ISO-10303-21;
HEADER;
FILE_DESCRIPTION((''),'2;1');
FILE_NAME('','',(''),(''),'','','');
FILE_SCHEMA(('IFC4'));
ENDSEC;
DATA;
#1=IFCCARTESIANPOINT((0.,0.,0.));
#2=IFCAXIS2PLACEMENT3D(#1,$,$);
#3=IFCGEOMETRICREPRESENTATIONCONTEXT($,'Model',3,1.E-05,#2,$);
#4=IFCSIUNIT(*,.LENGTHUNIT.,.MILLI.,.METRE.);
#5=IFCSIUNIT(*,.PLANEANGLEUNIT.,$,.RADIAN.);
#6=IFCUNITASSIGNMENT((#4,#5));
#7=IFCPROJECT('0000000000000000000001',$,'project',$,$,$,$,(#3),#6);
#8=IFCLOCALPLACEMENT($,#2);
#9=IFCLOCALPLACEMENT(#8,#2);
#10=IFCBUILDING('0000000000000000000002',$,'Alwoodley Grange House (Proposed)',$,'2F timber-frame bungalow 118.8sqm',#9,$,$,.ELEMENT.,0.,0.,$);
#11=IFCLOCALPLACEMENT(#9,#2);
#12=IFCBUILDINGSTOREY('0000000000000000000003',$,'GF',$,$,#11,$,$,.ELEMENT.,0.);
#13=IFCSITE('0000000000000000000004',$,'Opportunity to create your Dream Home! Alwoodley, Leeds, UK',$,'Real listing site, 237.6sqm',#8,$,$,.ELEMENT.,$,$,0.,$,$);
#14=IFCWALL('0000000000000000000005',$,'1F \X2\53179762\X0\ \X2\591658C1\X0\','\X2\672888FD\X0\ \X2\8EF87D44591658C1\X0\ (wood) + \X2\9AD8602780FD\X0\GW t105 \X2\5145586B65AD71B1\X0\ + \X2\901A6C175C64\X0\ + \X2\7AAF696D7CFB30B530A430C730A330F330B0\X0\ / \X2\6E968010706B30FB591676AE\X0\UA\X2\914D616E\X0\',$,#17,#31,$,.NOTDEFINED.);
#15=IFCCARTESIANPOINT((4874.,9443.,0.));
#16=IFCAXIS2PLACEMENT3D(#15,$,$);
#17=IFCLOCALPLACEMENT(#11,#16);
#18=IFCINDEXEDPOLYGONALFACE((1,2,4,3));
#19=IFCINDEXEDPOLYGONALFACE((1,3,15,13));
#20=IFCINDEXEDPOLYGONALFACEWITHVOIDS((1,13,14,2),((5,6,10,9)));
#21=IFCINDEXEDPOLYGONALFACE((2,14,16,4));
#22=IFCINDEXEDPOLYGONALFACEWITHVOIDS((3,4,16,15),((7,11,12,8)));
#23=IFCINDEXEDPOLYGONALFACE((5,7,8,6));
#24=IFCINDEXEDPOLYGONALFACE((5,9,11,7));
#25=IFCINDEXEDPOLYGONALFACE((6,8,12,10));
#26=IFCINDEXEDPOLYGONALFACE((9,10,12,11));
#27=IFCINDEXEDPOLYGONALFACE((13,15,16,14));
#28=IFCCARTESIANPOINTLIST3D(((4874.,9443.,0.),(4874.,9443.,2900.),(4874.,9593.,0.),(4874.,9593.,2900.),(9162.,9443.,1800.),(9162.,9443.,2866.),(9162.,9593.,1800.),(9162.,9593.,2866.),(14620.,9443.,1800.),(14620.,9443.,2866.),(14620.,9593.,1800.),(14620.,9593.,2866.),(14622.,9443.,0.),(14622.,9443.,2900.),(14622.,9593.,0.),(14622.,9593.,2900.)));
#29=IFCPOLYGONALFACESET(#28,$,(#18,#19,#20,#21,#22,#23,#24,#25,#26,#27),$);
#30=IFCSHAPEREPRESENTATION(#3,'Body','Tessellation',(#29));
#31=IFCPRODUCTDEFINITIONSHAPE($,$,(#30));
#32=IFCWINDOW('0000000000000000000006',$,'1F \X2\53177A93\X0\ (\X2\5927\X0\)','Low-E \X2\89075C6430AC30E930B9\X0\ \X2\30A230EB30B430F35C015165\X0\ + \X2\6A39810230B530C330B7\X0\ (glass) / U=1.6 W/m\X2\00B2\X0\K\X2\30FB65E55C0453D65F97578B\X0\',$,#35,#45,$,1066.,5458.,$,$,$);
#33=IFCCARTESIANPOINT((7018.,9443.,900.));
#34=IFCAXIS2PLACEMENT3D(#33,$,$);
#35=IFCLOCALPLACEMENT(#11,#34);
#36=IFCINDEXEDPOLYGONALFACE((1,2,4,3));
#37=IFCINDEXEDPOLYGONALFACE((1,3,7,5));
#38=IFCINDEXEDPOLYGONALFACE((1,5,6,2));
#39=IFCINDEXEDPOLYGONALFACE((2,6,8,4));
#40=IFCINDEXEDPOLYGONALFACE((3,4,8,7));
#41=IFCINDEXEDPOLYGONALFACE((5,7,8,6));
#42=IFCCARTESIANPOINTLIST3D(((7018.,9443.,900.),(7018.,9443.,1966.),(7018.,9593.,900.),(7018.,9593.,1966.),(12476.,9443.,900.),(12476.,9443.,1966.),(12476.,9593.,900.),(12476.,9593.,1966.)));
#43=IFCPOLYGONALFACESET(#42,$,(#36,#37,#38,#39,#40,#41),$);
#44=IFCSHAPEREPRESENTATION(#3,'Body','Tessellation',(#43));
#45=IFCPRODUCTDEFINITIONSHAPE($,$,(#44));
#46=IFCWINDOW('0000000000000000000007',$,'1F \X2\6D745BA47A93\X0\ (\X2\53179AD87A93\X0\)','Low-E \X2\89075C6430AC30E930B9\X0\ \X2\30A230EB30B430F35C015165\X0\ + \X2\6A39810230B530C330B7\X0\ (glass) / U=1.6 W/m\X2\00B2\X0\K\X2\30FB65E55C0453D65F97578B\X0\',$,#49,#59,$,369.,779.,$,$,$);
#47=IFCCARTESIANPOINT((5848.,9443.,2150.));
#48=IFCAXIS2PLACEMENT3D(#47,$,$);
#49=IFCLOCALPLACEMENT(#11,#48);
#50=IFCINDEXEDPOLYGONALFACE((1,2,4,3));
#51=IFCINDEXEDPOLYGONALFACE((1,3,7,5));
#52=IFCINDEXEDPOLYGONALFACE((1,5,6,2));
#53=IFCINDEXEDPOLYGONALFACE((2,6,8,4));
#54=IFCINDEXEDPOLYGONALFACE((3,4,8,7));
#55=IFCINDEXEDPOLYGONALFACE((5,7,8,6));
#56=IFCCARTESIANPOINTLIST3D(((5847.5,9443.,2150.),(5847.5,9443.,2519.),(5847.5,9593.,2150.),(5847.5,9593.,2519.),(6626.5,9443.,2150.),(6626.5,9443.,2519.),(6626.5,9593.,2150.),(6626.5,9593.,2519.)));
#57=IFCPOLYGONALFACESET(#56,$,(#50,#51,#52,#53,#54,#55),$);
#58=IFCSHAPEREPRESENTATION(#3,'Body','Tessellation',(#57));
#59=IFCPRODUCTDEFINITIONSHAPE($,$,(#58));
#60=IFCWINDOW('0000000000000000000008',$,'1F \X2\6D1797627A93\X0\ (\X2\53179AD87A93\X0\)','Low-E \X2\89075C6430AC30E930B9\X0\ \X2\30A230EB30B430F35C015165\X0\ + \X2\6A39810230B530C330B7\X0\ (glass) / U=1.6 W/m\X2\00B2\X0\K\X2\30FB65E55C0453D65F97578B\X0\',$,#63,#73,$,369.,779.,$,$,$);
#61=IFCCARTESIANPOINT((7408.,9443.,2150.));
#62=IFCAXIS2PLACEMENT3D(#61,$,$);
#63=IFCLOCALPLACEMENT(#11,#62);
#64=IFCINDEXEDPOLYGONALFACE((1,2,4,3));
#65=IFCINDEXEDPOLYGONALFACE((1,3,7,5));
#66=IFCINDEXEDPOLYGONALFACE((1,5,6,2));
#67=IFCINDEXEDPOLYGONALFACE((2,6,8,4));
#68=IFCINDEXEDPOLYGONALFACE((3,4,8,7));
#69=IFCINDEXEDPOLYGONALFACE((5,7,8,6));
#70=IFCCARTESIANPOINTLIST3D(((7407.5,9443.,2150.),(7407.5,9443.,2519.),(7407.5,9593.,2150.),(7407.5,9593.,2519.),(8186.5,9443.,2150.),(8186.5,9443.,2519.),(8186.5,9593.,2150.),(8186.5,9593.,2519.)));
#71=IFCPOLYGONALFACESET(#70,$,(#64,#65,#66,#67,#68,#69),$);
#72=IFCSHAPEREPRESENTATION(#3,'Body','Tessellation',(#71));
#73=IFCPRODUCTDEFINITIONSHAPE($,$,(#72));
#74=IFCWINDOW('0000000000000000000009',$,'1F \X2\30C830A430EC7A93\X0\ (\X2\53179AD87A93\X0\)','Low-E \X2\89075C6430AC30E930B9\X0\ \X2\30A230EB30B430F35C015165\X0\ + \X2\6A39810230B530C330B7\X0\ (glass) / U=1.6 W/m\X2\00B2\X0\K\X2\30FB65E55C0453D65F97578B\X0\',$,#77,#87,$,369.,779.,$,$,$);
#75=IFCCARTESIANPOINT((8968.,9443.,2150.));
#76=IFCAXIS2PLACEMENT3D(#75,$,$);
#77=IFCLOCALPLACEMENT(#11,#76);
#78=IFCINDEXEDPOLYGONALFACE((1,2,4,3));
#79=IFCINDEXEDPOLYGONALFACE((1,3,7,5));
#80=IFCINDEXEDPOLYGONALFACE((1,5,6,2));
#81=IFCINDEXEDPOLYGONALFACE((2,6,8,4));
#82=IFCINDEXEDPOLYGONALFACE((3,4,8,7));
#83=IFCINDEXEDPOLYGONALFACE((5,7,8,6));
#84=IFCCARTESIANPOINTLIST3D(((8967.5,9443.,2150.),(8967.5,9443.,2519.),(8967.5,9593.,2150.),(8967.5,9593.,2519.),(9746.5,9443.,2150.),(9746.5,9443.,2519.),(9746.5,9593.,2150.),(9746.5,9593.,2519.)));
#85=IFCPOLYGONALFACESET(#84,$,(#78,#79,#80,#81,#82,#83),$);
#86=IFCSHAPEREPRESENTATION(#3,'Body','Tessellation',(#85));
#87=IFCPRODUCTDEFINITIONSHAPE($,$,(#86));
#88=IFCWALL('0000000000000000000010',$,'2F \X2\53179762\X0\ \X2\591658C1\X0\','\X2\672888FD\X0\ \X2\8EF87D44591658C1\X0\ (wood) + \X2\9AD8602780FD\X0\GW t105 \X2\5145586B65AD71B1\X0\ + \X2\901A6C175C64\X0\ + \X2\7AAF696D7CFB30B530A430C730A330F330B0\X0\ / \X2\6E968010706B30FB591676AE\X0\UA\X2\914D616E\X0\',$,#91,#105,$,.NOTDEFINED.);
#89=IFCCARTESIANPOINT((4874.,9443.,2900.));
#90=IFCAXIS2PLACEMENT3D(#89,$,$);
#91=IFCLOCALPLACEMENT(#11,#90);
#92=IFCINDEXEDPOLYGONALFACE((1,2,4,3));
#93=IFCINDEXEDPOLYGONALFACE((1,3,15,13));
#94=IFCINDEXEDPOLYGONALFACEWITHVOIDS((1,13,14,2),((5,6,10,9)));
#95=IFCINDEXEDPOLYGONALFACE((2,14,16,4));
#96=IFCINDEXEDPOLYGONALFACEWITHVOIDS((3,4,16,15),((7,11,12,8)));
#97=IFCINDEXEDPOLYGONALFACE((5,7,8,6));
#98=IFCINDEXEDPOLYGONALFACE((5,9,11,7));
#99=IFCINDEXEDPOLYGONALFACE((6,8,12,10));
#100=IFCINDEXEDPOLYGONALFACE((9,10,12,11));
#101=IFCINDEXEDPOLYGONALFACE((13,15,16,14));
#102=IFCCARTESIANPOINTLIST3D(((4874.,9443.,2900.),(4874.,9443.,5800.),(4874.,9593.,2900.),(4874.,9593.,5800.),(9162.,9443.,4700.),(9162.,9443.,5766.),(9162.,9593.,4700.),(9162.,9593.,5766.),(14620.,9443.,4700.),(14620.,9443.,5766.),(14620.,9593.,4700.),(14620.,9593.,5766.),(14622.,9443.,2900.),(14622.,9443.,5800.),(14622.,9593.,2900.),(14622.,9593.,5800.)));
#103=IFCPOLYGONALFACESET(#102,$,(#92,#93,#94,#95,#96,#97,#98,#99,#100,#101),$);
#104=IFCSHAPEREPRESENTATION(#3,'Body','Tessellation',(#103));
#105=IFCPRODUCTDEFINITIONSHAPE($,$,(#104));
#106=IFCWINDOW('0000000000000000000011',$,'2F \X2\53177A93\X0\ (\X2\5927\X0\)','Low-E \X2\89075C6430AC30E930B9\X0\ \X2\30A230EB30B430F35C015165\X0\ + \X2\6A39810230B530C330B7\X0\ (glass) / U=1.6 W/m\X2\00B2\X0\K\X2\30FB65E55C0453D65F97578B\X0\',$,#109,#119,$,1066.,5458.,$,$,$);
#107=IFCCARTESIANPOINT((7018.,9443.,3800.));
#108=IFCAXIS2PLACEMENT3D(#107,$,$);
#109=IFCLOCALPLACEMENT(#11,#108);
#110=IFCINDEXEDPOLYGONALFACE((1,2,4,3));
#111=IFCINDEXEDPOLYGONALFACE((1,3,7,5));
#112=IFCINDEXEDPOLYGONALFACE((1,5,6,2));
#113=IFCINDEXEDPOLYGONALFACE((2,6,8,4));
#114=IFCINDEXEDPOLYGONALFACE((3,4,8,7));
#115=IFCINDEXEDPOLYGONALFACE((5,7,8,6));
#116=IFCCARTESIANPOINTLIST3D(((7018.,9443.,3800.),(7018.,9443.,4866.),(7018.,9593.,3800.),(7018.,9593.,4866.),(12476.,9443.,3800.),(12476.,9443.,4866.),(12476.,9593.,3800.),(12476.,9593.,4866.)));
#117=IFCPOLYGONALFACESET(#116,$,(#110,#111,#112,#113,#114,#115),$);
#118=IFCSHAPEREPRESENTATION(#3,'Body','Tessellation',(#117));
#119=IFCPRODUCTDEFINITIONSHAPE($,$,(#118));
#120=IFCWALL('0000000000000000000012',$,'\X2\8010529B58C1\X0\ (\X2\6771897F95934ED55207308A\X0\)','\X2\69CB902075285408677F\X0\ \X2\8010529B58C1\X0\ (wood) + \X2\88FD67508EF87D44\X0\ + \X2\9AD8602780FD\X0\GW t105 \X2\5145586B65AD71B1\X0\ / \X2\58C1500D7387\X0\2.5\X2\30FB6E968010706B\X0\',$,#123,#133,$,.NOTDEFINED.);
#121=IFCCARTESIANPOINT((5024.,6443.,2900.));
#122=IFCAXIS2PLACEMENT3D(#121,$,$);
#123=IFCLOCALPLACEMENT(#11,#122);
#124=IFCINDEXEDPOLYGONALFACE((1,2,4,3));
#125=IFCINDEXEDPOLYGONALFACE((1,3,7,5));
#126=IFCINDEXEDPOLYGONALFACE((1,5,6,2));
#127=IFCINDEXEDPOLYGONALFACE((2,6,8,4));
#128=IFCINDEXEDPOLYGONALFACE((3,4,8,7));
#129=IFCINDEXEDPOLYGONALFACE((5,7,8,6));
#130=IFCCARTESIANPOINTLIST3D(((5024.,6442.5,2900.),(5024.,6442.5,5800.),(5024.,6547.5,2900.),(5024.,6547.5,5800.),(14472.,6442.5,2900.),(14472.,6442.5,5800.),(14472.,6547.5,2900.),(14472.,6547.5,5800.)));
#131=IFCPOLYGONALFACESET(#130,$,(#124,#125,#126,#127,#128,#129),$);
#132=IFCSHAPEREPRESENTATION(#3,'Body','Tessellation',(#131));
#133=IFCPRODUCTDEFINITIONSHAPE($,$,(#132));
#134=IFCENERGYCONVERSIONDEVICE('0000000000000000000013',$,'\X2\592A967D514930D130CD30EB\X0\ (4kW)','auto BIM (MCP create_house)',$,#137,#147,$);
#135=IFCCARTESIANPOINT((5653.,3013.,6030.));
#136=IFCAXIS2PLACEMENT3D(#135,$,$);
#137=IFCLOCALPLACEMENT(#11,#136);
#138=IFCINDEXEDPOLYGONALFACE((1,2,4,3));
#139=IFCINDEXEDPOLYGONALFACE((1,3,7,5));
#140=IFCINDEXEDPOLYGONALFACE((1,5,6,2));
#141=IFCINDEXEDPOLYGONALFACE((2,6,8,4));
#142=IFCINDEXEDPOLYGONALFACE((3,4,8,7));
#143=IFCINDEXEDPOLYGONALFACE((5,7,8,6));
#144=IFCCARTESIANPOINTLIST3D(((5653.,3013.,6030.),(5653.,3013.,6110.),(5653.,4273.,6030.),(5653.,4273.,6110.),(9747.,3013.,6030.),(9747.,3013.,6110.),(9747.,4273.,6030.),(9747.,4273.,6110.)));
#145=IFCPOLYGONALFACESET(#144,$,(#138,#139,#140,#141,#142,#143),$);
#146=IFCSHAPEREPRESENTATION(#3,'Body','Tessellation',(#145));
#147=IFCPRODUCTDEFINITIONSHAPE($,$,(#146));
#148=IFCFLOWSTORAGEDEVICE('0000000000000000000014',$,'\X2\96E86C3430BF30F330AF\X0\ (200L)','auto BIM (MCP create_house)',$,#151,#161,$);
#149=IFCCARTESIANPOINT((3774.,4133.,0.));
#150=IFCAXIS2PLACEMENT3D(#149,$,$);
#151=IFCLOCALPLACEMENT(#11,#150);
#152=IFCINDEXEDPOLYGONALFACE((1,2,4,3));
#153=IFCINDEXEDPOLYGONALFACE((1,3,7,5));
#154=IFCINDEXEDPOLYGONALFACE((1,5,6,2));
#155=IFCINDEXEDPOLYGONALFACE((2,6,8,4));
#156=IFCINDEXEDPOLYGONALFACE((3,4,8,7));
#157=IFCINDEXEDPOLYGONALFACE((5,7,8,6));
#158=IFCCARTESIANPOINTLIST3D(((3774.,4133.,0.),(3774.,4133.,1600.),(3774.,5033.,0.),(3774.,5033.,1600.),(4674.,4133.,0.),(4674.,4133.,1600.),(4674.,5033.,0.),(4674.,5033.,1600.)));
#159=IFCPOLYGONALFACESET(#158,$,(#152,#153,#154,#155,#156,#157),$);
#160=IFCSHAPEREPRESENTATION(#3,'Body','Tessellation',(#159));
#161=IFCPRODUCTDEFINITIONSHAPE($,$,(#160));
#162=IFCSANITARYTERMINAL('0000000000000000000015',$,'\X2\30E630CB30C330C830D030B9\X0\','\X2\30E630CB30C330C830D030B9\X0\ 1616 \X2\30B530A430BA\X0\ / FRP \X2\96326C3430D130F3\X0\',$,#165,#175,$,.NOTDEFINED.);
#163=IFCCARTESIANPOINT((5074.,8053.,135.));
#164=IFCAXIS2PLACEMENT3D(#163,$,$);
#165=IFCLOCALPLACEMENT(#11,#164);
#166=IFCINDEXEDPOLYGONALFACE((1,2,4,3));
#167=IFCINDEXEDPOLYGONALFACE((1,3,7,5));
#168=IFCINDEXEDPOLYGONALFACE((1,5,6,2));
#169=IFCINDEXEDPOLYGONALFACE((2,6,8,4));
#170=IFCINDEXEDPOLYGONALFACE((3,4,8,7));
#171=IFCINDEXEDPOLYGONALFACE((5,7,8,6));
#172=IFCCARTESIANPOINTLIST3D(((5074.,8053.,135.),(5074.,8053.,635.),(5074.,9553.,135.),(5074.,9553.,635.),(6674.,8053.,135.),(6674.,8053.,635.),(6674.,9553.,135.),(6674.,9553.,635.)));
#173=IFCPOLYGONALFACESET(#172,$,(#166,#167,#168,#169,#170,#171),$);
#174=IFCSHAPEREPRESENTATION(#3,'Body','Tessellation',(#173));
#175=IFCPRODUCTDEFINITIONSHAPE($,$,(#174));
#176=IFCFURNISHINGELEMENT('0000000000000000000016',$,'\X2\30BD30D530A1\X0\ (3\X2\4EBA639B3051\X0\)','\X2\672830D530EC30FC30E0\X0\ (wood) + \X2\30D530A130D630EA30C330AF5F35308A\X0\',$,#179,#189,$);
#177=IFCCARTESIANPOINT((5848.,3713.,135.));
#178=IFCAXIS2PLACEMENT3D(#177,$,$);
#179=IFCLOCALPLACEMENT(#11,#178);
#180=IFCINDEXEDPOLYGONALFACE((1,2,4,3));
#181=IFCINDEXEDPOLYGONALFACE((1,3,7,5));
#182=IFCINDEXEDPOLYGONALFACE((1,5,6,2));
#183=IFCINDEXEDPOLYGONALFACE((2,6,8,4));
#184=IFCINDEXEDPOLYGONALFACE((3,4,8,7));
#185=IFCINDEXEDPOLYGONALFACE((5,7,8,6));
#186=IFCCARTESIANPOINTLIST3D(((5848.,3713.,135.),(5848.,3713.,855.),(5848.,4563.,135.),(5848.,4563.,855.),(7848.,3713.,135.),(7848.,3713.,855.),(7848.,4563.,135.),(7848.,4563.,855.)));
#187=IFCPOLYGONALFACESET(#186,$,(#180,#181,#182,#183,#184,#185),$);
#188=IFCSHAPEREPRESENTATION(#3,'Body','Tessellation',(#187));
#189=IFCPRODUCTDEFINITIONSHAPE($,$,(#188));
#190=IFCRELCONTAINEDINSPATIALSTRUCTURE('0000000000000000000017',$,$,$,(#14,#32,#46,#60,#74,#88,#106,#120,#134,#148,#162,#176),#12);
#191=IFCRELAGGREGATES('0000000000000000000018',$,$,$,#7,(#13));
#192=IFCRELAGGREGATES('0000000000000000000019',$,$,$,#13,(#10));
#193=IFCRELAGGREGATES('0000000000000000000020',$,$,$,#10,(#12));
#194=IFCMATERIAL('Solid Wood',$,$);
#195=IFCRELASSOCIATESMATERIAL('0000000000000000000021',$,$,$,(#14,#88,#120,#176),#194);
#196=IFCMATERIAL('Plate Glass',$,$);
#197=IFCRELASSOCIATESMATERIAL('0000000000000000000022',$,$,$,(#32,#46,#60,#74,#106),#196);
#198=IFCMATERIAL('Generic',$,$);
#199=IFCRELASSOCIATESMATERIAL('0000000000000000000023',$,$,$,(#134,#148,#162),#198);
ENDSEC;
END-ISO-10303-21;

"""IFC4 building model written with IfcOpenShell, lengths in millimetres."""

from ifc_helpers import new_model, si_unit, frame, frame_2d, origin, place, context, project, spatial, rectangle, extrude, material, element, fill, save


model = new_model("IFC4")

# Units and contexts
model_context = context("Model", 3, precision=1e-05, world=origin())
ifc_project = project(units=[si_unit("LENGTHUNIT", "METRE", prefix="MILLI"), si_unit("PLANEANGLEUNIT", "RADIAN")], contexts=[model_context])

# Site, building, storey
site_placement = place(None, origin())
site = spatial("IfcSite", under=ifc_project, at=site_placement, Name="Opportunity to create your Dream Home! Alwoodley, Leeds, UK", ObjectType="Real listing site, 237.6sqm", CompositionType="ELEMENT", RefElevation=0.0)
building_placement = place(site_placement, origin())
building = spatial("IfcBuilding", under=site, at=building_placement, Name="Alwoodley Grange House (Proposed)", ObjectType="2F timber-frame bungalow 118.8sqm", CompositionType="ELEMENT", ElevationOfRefHeight=0.0, ElevationOfTerrain=0.0)
storey_placement = place(building_placement, origin())
storey = spatial("IfcBuildingStorey", under=building, at=storey_placement, Name="GF", CompositionType="ELEMENT", Elevation=0.0)

# Wall, openings, windows
ifc_material_1 = material(Name="Solid Wood")
wall_1_placement = place(storey_placement, frame((4874.0, 9443.0, 0.0)))
wall_1 = element("IfcWall", 1, at=wall_1_placement, inside=storey, material=ifc_material_1, Name="1F 北面 外壁", Description="木製 軸組外壁 (wood) + 高性能GW t105 充填断熱 + 通気層 + 窯業系サイディング / 準耐火・外皮UA配慮", PredefinedType="NOTDEFINED", context=model_context, shape_type="SweptSolid", body=[
    extrude(rectangle(XDim=9748.0, YDim=150.0, at=frame_2d((4874.0, 75.0))), frame((4874.0, 9443.0, 0.0)), (0.0, 0.0, 1.0), 2900.0),
])
opening_1_placement = place(storey_placement, frame((7018.0, 9443.0, 900.0)))
opening_1 = element("IfcOpeningElement", 2, at=opening_1_placement, cuts=wall_1, PredefinedType="NOTDEFINED", context=model_context, shape_type="SweptSolid", body=[
    extrude(rectangle(XDim=5458.0, YDim=150.0, at=frame_2d((2729.0, 75.0))), frame((7018.0, 9443.0, 900.0)), (0.0, 0.0, 1.0), 1066.0),
])
opening_2_placement = place(storey_placement, frame((5848.0, 9443.0, 2150.0)))
opening_2 = element("IfcOpeningElement", 3, at=opening_2_placement, cuts=wall_1, PredefinedType="NOTDEFINED", context=model_context, shape_type="SweptSolid", body=[
    extrude(rectangle(XDim=779.0, YDim=150.0, at=frame_2d((389.0, 75.0))), frame((5848.0, 9443.0, 2150.0)), (0.0, 0.0, 1.0), 369.0),
])
opening_3_placement = place(storey_placement, frame((7408.0, 9443.0, 2150.0)))
opening_3 = element("IfcOpeningElement", 4, at=opening_3_placement, cuts=wall_1, PredefinedType="NOTDEFINED", context=model_context, shape_type="SweptSolid", body=[
    extrude(rectangle(XDim=779.0, YDim=150.0, at=frame_2d((389.0, 75.0))), frame((7408.0, 9443.0, 2150.0)), (0.0, 0.0, 1.0), 369.0),
])
opening_4_placement = place(storey_placement, frame((8968.0, 9443.0, 2150.0)))
opening_4 = element("IfcOpeningElement", 5, at=opening_4_placement, cuts=wall_1, PredefinedType="NOTDEFINED", context=model_context, shape_type="SweptSolid", body=[
    extrude(rectangle(XDim=779.0, YDim=150.0, at=frame_2d((389.0, 75.0))), frame((8968.0, 9443.0, 2150.0)), (0.0, 0.0, 1.0), 369.0),
])
ifc_material_2 = material(Name="Plate Glass")
window_1_placement = place(storey_placement, frame((7018.0, 9443.0, 900.0)))
window_1 = element("IfcWindow", 6, at=window_1_placement, inside=storey, material=ifc_material_2, Name="1F 北窓 (大)", Description="Low-E 複層ガラス アルゴン封入 + 樹脂サッシ (glass) / U=1.6 W/m²K・日射取得型", OverallHeight=1066.0, OverallWidth=5458.0, context=model_context, shape_type="SweptSolid", body=[
    extrude(rectangle(XDim=5458.0, YDim=150.0, at=frame_2d((2729.0, 75.0))), frame((7018.0, 9443.0, 900.0)), (0.0, 0.0, 1.0), 1066.0),
])
fill(opening_1, window_1)
window_2_placement = place(storey_placement, frame((5848.0, 9443.0, 2150.0)))
window_2 = element("IfcWindow", 7, at=window_2_placement, inside=storey, material=ifc_material_2, Name="1F 浴室窓 (北高窓)", Description="Low-E 複層ガラス アルゴン封入 + 樹脂サッシ (glass) / U=1.6 W/m²K・日射取得型", OverallHeight=369.0, OverallWidth=779.0, context=model_context, shape_type="SweptSolid", body=[
    extrude(rectangle(XDim=779.0, YDim=150.0, at=frame_2d((389.0, 75.0))), frame((5848.0, 9443.0, 2150.0)), (0.0, 0.0, 1.0), 369.0),
])
fill(opening_2, window_2)
window_3_placement = place(storey_placement, frame((7408.0, 9443.0, 2150.0)))
window_3 = element("IfcWindow", 8, at=window_3_placement, inside=storey, material=ifc_material_2, Name="1F 洗面窓 (北高窓)", Description="Low-E 複層ガラス アルゴン封入 + 樹脂サッシ (glass) / U=1.6 W/m²K・日射取得型", OverallHeight=369.0, OverallWidth=779.0, context=model_context, shape_type="SweptSolid", body=[
    extrude(rectangle(XDim=779.0, YDim=150.0, at=frame_2d((389.0, 75.0))), frame((7408.0, 9443.0, 2150.0)), (0.0, 0.0, 1.0), 369.0),
])
fill(opening_3, window_3)
window_4_placement = place(storey_placement, frame((8968.0, 9443.0, 2150.0)))
window_4 = element("IfcWindow", 9, at=window_4_placement, inside=storey, material=ifc_material_2, Name="1F トイレ窓 (北高窓)", Description="Low-E 複層ガラス アルゴン封入 + 樹脂サッシ (glass) / U=1.6 W/m²K・日射取得型", OverallHeight=369.0, OverallWidth=779.0, context=model_context, shape_type="SweptSolid", body=[
    extrude(rectangle(XDim=779.0, YDim=150.0, at=frame_2d((389.0, 75.0))), frame((8968.0, 9443.0, 2150.0)), (0.0, 0.0, 1.0), 369.0),
])
fill(opening_4, window_4)

# Wall, opening, window
wall_2_placement = place(storey_placement, frame((4874.0, 9443.0, 2900.0)))
wall_2 = element("IfcWall", 10, at=wall_2_placement, inside=storey, material=ifc_material_1, Name="2F 北面 外壁", Description="木製 軸組外壁 (wood) + 高性能GW t105 充填断熱 + 通気層 + 窯業系サイディング / 準耐火・外皮UA配慮", PredefinedType="NOTDEFINED", context=model_context, shape_type="SweptSolid", body=[
    extrude(rectangle(XDim=9748.0, YDim=150.0, at=frame_2d((4874.0, 75.0))), frame((4874.0, 9443.0, 2900.0)), (0.0, 0.0, 1.0), 2900.0),
])
opening_5_placement = place(storey_placement, frame((7018.0, 9443.0, 3800.0)))
opening_5 = element("IfcOpeningElement", 11, at=opening_5_placement, cuts=wall_2, PredefinedType="NOTDEFINED", context=model_context, shape_type="SweptSolid", body=[
    extrude(rectangle(XDim=5458.0, YDim=150.0, at=frame_2d((2729.0, 75.0))), frame((7018.0, 9443.0, 3800.0)), (0.0, 0.0, 1.0), 1066.0),
])
window_5_placement = place(storey_placement, frame((7018.0, 9443.0, 3800.0)))
window_5 = element("IfcWindow", 12, at=window_5_placement, inside=storey, material=ifc_material_2, Name="2F 北窓 (大)", Description="Low-E 複層ガラス アルゴン封入 + 樹脂サッシ (glass) / U=1.6 W/m²K・日射取得型", OverallHeight=1066.0, OverallWidth=5458.0, context=model_context, shape_type="SweptSolid", body=[
    extrude(rectangle(XDim=5458.0, YDim=150.0, at=frame_2d((2729.0, 75.0))), frame((7018.0, 9443.0, 3800.0)), (0.0, 0.0, 1.0), 1066.0),
])
fill(opening_5, window_5)

# Wall
wall_3_placement = place(storey_placement, frame((5024.0, 6443.0, 2900.0)))
element("IfcWall", 13, at=wall_3_placement, inside=storey, material=ifc_material_1, Name="耐力壁 (東西間仕切り)", Description="構造用合板 耐力壁 (wood) + 製材軸組 + 高性能GW t105 充填断熱 / 壁倍率2.5・準耐火", PredefinedType="NOTDEFINED", context=model_context, shape_type="SweptSolid", body=[
    extrude(rectangle(XDim=9448.0, YDim=105.0, at=frame_2d((4724.0, 52.0))), frame((5024.0, 6443.0, 2900.0)), (0.0, 0.0, 1.0), 2900.0),
])

# Energy conversion device
ifc_material_3 = material(Name="Generic")
energy_conversion_device_placement = place(storey_placement, frame((5653.0, 3013.0, 6030.0)))
element("IfcEnergyConversionDevice", 14, at=energy_conversion_device_placement, inside=storey, material=ifc_material_3, Name="太陽光パネル (4kW)", Description="auto BIM (MCP create_house)", context=model_context, shape_type="SweptSolid", body=[
    extrude(rectangle(XDim=4094.0, YDim=1260.0, at=frame_2d((2047.0, 630.0))), frame((5653.0, 3013.0, 6030.0)), (0.0, 0.0, 1.0), 80.0),
])

# Flow storage device
flow_storage_device_placement = place(storey_placement, frame((3774.0, 4133.0, 0.0)))
element("IfcFlowStorageDevice", 15, at=flow_storage_device_placement, inside=storey, material=ifc_material_3, Name="雨水タンク (200L)", Description="auto BIM (MCP create_house)", context=model_context, shape_type="SweptSolid", body=[
    extrude(rectangle(XDim=900.0, YDim=900.0, at=frame_2d((450.0, 450.0))), frame((3774.0, 4133.0, 0.0)), (0.0, 0.0, 1.0), 1600.0),
])

# Sanitary terminal
sanitary_terminal_placement = place(storey_placement, frame((5074.0, 8053.0, 135.0)))
element("IfcSanitaryTerminal", 16, at=sanitary_terminal_placement, inside=storey, material=ifc_material_3, Name="ユニットバス", Description="ユニットバス 1616 サイズ / FRP 防水パン", PredefinedType="NOTDEFINED", context=model_context, shape_type="SweptSolid", body=[
    extrude(rectangle(XDim=1600.0, YDim=1500.0, at=frame_2d((800.0, 750.0))), frame((5074.0, 8053.0, 135.0)), (0.0, 0.0, 1.0), 500.0),
])

# Furnishing element
furnishing_1_placement = place(storey_placement, frame((5848.0, 3713.0, 135.0)))
element("IfcFurnishingElement", 17, at=furnishing_1_placement, inside=storey, material=ifc_material_1, Name="ソファ (3人掛け)", Description="木フレーム (wood) + ファブリック張り", context=model_context, shape_type="SweptSolid", body=[
    extrude(rectangle(XDim=2000.0, YDim=850.0, at=frame_2d((1000.0, 425.0))), frame((5848.0, 3713.0, 135.0)), (0.0, 0.0, 1.0), 720.0),
])

save(model, "model.ifc")
